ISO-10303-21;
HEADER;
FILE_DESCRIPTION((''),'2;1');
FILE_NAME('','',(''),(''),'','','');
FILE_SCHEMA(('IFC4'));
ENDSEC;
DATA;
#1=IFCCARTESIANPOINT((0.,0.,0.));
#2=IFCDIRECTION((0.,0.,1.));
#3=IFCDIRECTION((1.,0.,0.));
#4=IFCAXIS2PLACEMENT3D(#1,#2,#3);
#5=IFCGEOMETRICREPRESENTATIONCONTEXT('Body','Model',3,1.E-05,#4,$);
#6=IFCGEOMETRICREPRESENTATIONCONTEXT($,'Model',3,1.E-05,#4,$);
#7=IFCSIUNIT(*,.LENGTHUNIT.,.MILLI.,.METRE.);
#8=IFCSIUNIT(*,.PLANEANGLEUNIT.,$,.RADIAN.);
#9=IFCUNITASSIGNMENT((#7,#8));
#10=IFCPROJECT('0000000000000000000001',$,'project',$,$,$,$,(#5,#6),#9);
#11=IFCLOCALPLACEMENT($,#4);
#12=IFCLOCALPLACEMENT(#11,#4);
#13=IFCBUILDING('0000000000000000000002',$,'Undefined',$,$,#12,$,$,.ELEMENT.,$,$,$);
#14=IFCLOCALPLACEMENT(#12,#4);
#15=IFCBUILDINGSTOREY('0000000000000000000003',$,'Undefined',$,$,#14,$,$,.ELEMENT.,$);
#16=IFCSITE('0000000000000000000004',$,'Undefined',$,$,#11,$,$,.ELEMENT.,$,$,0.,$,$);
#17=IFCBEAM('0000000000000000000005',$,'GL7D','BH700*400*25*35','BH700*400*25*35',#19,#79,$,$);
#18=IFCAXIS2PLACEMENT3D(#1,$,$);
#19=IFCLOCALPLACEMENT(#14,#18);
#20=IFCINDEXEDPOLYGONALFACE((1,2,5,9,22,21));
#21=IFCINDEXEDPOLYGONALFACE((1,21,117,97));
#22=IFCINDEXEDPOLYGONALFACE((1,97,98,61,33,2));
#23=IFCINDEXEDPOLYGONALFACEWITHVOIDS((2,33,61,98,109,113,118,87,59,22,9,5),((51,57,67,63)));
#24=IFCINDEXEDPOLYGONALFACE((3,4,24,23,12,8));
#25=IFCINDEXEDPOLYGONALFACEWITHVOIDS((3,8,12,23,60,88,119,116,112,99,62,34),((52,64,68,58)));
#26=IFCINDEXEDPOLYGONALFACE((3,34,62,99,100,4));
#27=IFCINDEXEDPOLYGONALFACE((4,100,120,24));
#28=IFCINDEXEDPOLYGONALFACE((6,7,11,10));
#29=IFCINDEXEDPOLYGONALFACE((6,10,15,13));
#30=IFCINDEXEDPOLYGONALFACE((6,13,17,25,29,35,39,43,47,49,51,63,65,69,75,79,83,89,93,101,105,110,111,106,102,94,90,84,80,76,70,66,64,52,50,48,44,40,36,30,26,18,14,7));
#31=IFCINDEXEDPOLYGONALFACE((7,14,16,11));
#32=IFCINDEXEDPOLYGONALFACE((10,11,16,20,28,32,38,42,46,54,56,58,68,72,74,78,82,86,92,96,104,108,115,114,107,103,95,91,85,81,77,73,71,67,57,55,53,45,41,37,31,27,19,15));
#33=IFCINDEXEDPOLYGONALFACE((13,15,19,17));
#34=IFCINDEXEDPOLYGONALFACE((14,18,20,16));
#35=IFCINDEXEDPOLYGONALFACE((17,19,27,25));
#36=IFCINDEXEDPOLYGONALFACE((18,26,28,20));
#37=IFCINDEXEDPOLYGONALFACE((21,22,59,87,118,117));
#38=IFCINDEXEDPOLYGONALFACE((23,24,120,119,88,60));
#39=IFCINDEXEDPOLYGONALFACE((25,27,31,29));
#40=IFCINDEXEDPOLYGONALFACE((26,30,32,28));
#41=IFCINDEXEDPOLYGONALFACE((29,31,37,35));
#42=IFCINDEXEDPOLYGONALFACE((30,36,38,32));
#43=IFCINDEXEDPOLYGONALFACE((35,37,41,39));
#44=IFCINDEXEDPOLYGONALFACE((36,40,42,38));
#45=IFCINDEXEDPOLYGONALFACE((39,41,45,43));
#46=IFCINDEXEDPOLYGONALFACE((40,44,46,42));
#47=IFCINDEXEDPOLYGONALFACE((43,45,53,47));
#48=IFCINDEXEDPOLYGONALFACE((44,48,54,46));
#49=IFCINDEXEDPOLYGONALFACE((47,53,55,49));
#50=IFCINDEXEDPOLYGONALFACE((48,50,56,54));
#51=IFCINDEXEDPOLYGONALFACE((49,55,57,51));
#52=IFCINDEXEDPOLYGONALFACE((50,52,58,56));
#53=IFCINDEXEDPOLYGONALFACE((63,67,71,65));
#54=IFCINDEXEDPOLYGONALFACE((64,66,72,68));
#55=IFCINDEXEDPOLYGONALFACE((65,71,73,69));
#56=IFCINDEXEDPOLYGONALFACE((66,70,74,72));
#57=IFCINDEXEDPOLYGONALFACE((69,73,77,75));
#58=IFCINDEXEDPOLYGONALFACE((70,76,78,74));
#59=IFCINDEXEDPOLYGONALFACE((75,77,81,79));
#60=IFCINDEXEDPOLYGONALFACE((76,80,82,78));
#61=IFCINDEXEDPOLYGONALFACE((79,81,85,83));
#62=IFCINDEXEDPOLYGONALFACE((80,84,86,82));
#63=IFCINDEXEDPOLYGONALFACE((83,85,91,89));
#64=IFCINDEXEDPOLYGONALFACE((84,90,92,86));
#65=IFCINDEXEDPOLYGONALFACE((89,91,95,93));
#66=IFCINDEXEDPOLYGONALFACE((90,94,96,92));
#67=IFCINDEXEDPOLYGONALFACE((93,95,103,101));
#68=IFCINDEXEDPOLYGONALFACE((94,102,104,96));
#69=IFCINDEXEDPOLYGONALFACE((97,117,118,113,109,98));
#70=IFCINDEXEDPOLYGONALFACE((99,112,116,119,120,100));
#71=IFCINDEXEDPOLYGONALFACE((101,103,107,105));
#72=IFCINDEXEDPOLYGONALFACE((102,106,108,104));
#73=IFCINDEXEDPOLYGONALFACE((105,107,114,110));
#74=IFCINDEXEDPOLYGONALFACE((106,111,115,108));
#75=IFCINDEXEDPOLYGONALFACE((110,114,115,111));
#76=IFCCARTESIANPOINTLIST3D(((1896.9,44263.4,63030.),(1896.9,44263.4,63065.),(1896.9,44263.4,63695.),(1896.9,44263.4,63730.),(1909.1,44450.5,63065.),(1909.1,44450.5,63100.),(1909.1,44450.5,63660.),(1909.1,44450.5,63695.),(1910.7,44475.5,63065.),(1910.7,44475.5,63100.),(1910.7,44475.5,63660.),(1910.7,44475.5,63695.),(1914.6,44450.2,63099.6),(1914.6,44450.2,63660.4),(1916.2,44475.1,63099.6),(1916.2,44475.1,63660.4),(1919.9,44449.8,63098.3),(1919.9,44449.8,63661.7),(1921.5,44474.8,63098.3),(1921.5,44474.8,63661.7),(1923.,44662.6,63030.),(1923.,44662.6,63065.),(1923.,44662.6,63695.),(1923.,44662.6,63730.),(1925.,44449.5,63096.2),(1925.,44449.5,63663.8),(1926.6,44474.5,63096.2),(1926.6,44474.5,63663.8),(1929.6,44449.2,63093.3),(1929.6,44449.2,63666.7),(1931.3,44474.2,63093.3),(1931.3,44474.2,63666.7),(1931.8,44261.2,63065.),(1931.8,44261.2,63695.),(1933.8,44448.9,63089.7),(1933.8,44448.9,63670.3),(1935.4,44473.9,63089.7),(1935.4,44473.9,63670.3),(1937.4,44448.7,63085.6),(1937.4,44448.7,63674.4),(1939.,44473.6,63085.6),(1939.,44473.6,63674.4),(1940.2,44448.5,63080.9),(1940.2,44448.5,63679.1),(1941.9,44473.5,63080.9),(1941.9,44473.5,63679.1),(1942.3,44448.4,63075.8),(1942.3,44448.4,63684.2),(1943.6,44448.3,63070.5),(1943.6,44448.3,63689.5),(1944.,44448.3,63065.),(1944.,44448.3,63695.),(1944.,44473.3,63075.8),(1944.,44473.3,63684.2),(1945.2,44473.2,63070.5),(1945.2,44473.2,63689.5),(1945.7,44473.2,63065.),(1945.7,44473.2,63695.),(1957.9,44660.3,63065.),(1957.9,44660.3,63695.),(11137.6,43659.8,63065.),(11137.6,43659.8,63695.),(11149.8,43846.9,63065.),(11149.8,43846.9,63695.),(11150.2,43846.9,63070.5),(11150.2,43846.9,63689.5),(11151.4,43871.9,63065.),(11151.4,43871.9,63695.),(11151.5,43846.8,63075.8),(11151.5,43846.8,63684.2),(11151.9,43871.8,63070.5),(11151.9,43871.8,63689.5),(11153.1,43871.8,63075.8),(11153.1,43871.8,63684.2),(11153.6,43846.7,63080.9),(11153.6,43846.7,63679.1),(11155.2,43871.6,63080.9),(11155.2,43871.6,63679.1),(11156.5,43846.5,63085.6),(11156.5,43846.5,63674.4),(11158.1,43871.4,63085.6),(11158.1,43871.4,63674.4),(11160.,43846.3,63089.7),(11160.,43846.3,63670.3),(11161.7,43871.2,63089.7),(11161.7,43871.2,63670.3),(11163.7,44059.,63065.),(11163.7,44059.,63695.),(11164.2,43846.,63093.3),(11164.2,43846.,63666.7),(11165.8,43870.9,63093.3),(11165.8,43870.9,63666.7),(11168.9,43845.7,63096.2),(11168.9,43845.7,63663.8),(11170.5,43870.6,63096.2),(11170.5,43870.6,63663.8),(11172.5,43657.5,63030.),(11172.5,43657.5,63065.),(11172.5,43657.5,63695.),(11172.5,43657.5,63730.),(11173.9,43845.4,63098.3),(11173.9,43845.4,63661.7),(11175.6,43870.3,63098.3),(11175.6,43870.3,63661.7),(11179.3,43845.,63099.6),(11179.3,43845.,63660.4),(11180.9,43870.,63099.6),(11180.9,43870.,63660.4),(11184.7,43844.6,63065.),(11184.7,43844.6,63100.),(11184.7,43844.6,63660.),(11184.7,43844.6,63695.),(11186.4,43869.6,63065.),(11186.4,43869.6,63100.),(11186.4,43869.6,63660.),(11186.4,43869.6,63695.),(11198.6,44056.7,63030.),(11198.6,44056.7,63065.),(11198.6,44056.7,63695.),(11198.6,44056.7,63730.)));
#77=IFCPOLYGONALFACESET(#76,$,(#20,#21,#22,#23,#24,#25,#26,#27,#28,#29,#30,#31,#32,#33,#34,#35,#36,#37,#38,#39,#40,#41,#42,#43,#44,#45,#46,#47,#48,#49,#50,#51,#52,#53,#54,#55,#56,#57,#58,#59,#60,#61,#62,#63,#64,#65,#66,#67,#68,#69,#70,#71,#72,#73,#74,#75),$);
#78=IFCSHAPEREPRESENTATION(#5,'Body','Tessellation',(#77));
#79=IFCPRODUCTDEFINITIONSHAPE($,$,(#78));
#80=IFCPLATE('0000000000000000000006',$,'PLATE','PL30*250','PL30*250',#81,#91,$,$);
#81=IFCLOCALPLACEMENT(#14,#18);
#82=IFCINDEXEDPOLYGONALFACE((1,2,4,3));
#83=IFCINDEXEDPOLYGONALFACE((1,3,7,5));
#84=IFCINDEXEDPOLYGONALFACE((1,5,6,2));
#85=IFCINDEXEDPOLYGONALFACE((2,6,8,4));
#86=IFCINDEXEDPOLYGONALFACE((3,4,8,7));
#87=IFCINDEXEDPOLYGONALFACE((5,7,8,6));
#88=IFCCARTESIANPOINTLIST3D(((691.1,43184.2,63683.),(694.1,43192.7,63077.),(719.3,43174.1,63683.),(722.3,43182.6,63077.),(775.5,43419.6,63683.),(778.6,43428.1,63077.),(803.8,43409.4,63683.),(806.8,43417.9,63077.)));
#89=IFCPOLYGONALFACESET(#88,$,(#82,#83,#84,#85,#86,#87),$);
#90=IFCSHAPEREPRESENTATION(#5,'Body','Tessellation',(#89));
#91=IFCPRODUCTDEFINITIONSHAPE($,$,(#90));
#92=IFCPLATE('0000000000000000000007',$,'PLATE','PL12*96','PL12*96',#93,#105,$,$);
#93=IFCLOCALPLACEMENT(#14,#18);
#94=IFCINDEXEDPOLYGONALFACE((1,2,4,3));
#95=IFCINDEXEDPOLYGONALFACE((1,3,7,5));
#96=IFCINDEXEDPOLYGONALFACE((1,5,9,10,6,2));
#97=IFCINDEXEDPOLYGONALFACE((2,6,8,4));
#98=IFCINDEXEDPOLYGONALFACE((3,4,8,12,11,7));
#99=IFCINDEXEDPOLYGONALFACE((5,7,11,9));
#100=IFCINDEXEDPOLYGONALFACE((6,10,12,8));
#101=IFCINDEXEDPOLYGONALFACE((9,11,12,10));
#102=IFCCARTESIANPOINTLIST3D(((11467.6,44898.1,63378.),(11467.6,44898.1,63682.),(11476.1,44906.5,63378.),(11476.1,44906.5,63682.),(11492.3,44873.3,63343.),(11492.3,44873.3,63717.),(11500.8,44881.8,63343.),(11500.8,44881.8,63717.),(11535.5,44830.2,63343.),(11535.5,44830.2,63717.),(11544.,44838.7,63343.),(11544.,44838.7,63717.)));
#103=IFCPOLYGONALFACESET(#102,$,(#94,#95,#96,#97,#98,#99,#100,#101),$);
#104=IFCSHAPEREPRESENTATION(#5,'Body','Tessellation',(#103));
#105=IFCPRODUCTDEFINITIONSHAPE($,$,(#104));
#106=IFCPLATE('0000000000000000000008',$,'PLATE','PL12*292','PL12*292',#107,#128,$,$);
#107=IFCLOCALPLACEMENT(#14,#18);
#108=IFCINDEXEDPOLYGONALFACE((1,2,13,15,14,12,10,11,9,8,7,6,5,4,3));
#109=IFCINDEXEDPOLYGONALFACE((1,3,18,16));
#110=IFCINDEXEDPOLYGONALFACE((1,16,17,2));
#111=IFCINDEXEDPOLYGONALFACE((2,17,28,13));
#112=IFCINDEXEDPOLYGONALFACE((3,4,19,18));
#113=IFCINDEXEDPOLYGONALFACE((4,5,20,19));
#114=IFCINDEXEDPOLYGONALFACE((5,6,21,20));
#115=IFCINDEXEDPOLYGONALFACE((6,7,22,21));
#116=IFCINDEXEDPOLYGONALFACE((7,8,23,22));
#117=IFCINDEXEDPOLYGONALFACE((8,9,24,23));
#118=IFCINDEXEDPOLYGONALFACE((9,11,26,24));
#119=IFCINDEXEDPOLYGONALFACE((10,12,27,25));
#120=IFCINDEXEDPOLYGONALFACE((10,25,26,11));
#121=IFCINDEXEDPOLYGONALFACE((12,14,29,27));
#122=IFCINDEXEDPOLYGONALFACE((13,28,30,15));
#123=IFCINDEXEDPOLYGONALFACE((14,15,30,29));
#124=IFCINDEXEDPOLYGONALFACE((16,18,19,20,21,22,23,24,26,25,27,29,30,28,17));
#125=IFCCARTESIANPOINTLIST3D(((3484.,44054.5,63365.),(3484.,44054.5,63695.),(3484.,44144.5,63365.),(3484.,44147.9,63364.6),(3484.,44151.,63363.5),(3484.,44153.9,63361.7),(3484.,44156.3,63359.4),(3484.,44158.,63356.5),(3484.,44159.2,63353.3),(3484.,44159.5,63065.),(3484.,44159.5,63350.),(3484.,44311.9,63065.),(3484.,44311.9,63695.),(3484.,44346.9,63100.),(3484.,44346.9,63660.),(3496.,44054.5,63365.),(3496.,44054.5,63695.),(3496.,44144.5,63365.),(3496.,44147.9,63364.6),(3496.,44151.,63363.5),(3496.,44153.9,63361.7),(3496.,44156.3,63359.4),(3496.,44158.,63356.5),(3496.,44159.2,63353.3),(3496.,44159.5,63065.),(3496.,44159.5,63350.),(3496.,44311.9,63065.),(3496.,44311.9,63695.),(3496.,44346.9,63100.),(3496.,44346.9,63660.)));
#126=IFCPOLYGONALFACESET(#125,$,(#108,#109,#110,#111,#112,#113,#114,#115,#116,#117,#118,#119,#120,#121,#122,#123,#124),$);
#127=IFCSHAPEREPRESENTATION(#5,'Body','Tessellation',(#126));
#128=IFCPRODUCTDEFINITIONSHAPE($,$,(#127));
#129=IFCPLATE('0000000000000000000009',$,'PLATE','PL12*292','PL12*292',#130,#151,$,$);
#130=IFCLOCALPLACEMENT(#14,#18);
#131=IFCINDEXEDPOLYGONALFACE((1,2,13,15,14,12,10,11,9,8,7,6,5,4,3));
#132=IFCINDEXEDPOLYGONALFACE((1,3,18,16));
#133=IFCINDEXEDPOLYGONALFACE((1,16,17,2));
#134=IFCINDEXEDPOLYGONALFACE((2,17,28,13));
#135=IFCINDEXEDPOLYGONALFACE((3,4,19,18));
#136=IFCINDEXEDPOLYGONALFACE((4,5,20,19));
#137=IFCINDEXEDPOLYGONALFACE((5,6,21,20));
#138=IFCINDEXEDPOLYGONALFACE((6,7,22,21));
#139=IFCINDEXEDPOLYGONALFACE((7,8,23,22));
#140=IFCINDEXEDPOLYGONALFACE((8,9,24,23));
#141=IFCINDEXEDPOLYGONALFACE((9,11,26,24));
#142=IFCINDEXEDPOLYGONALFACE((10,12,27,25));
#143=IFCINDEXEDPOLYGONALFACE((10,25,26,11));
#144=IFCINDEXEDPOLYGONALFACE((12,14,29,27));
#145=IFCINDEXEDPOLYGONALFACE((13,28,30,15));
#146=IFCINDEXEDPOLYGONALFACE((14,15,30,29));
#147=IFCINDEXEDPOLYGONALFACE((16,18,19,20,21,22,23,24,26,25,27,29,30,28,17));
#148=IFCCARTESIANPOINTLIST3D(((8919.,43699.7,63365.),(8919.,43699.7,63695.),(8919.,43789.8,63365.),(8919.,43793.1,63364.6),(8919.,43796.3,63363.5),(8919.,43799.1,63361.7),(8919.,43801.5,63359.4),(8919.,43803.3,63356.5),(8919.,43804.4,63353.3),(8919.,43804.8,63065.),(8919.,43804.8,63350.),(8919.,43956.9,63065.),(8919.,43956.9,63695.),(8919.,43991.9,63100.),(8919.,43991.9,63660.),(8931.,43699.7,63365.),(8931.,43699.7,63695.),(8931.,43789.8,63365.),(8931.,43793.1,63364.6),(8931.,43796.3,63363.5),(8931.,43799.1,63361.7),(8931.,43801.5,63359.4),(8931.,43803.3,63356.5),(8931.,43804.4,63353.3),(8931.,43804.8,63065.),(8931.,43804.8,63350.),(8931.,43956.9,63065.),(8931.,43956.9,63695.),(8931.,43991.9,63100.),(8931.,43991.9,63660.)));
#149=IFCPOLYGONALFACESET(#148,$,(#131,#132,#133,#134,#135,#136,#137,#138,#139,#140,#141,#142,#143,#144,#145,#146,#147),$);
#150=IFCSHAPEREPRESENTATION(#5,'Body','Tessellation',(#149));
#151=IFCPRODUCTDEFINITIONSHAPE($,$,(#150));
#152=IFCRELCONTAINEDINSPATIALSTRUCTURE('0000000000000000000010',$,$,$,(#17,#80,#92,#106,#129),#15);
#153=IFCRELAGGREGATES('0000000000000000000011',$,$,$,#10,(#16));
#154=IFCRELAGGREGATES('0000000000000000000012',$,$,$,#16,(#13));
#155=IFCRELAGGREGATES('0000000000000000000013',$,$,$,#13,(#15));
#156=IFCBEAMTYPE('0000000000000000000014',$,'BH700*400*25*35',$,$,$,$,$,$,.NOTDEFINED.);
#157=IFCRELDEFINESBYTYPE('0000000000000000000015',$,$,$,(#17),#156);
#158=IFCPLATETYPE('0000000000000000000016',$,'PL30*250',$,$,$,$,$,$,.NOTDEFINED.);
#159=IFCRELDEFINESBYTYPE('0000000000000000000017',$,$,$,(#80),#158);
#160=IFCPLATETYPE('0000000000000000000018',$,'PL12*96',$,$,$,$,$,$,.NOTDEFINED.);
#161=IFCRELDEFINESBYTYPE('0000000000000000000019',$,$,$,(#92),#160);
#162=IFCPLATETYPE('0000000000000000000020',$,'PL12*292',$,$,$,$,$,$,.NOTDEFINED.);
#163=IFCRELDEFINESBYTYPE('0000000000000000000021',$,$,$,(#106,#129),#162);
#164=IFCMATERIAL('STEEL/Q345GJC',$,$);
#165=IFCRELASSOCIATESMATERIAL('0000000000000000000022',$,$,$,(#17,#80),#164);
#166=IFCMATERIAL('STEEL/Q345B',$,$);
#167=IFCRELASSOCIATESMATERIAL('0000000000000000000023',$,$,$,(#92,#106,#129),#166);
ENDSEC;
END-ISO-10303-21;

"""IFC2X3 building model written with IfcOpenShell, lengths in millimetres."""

from ifc_helpers import new_model, si_unit, frame, origin_with_axes, origin_2d_with_axis, place, context, project, spatial, polyline, i_section, outline, extrude, material, type_object, element, save


model = new_model("IFC2X3")

# Units and contexts
model_context_1 = context("Model", 3, precision=1e-05, world=origin_with_axes(), identifier="Body")
model_context_2 = context("Model", 3, precision=1e-05, world=origin_with_axes())
ifc_project = project(units=[si_unit("LENGTHUNIT", "METRE", prefix="MILLI"), si_unit("PLANEANGLEUNIT", "RADIAN")], contexts=[model_context_1, model_context_2])

# Site, building, storey
site_placement = place(None, origin_with_axes())
site = spatial("IfcSite", under=ifc_project, at=site_placement, Name="Undefined", CompositionType="ELEMENT", RefElevation=0.0)
building_placement = place(site_placement, origin_with_axes())
building = spatial("IfcBuilding", under=site, at=building_placement, Name="Undefined", CompositionType="ELEMENT")
storey_placement = place(building_placement, origin_with_axes())
storey = spatial("IfcBuildingStorey", under=building, at=storey_placement, Name="Undefined", CompositionType="ELEMENT")

# Shared definitions
ifc_material_1 = material(Name="STEEL/Q345B")
ifc_material_2 = material(Name="STEEL/Q345GJC")

# Beam, openings
beam_type_1 = type_object("IfcBeamType", Name="BH700*400*25*35", PredefinedType="NOTDEFINED")
beam_1_placement = place(storey_placement, frame((992.3, 44523.0, 63380.0), z_axis=(0.0, 0.0, 1.0), x_axis=(0.997873, -0.065183, 0.0)))
beam_1 = element("IfcBeam", 1, at=beam_1_placement, inside=storey, type_object=beam_type_1, material=ifc_material_2, Name="GL7D", Description="BH700*400*25*35", ObjectType="BH700*400*25*35", context=model_context_1, shape_type="SweptSolid", body=[
    extrude(i_section(OverallWidth=400.0, OverallDepth=700.0, WebThickness=25.0, FlangeThickness=35.0, at=origin_2d_with_axis()), frame((10215.0, 0.0, 0.0), z_axis=(-1.0, 0.0, 0.0), x_axis=(0.0, -1.0, 0.0)), (0.0, 0.0, 1.0), 9295.4),
])
opening_1_placement = place(storey_placement, frame((992.3, 44523.0, 63380.0), z_axis=(0.0, 0.0, 1.0), x_axis=(0.997873, -0.065183, 0.0)))
element("IfcOpeningElement", 2, at=opening_1_placement, cuts=beam_1, ObjectType="Recess", context=model_context_1, shape_type="SweptSolid", body=[
    extrude(outline(polyline([(0.0, 0.0), (37.0, 0.0), (37.0, 35.0), (35.0, 35.0), (29.5, 34.6), (24.2, 33.3), (19.1, 31.2), (14.4, 28.3), (10.3, 24.7), (6.7, 20.6), (3.8, 15.9), (1.7, 10.8), (0.4, 5.5), (0.0, 0.0), (0.0, 0.0)])), frame((10180.0, -200.0, 315.0), z_axis=(0.0, 1.0, 0.0), x_axis=(1.0, 0.0, 0.0)), (0.0, 0.0, 1.0), 400.0),
])
opening_2_placement = place(storey_placement, frame((992.3, 44523.0, 63380.0), z_axis=(0.0, 0.0, 1.0), x_axis=(0.997873, -0.065183, 0.0)))
element("IfcOpeningElement", 3, at=opening_2_placement, cuts=beam_1, ObjectType="Recess", context=model_context_1, shape_type="SweptSolid", body=[
    extrude(outline(polyline([(0.0, 0.0), (37.0, 0.0), (36.6, 5.5), (35.3, 10.8), (33.2, 15.9), (30.3, 20.6), (26.7, 24.7), (22.6, 28.3), (17.9, 31.2), (12.8, 33.3), (7.5, 34.6), (2.0, 35.0), (0.0, 35.0), (0.0, 0.0)])), frame((10217.0, -200.0, -315.0), z_axis=(0.0, 1.0, 0.0), x_axis=(-1.0, 0.0, 0.0)), (0.0, 0.0, 1.0), 400.0),
])
opening_3_placement = place(storey_placement, frame((992.3, 44523.0, 63380.0), z_axis=(0.0, 0.0, 1.0), x_axis=(0.997873, -0.065183, 0.0)))
element("IfcOpeningElement", 4, at=opening_3_placement, cuts=beam_1, ObjectType="Recess", context=model_context_1, shape_type="SweptSolid", body=[
    extrude(outline(polyline([(0.0, 0.0), (37.0, 0.0), (37.0, 35.0), (35.0, 35.0), (29.5, 34.6), (24.2, 33.3), (19.1, 31.2), (14.4, 28.3), (10.3, 24.7), (6.7, 20.6), (3.8, 15.9), (1.7, 10.8), (0.4, 5.5), (0.0, 0.0), (0.0, 0.0)])), frame((954.6, 200.0, 315.0), z_axis=(0.0, -1.0, 0.0), x_axis=(-1.0, 0.0, 0.0)), (0.0, 0.0, 1.0), 400.0),
])
opening_4_placement = place(storey_placement, frame((992.3, 44523.0, 63380.0), z_axis=(0.0, 0.0, 1.0), x_axis=(0.997873, -0.065183, 0.0)))
element("IfcOpeningElement", 5, at=opening_4_placement, cuts=beam_1, ObjectType="Recess", context=model_context_1, shape_type="SweptSolid", body=[
    extrude(outline(polyline([(0.0, 0.0), (37.0, 0.0), (36.6, 5.5), (35.3, 10.8), (33.2, 15.9), (30.3, 20.6), (26.7, 24.7), (22.6, 28.3), (17.9, 31.2), (12.8, 33.3), (7.5, 34.6), (2.0, 35.0), (0.0, 35.0), (0.0, 0.0)])), frame((917.6, 200.0, -315.0), z_axis=(0.0, -1.0, 0.0), x_axis=(1.0, 0.0, 0.0)), (0.0, 0.0, 1.0), 400.0),
])
opening_5_placement = place(storey_placement, frame((992.3, 44523.0, 63380.0), z_axis=(0.0, 0.0, 1.0), x_axis=(0.997873, -0.065183, 0.0)))
element("IfcOpeningElement", 6, at=opening_5_placement, cuts=beam_1, ObjectType="Recess", context=model_context_1, shape_type="SweptSolid", body=[
    extrude(outline(polyline([(0.0, 0.0), (37.0, 0.0), (37.0, 35.0), (35.0, 35.0), (29.5, 34.6), (24.2, 33.3), (19.1, 31.2), (14.4, 28.3), (10.3, 24.7), (6.7, 20.6), (3.8, 15.9), (1.7, 10.8), (0.4, 5.5), (0.0, 0.0), (0.0, 0.0)])), frame((10437.3, 10608.1, 315.0), z_axis=(-0.991502, -0.130088, 0.0), x_axis=(-0.130088, 0.991502, 0.0)), (0.0, 0.0, 1.0), 400.0),
])
opening_6_placement = place(storey_placement, frame((992.3, 44523.0, 63380.0), z_axis=(0.0, 0.0, 1.0), x_axis=(0.997873, -0.065183, 0.0)))
element("IfcOpeningElement", 7, at=opening_6_placement, cuts=beam_1, ObjectType="Recess", context=model_context_1, shape_type="SweptSolid", body=[
    extrude(outline(polyline([(0.0, 0.0), (37.0, 0.0), (36.6, 5.5), (35.3, 10.8), (33.2, 15.9), (30.3, 20.6), (26.7, 24.7), (22.6, 28.3), (17.9, 31.2), (12.8, 33.3), (7.5, 34.6), (2.0, 35.0), (0.0, 35.0), (0.0, 0.0)])), frame((10432.5, 10644.8, -315.0), z_axis=(-0.991502, -0.130088, 0.0), x_axis=(0.130088, -0.991502, 0.0)), (0.0, 0.0, 1.0), 400.0),
])

# Plates
plate_type_1 = type_object("IfcPlateType", Name="PL30*250", PredefinedType="NOTDEFINED")
plate_1_placement = place(storey_placement, frame((705.2, 43179.2, 63683.0), z_axis=(-0.941212, 0.337816, 0.0), x_axis=(0.337816, 0.941212, 0.0)))
element("IfcPlate", 8, at=plate_1_placement, inside=storey, type_object=plate_type_1, material=ifc_material_2, Name="PLATE", Description="PL30*250", ObjectType="PL30*250", context=model_context_1, shape_type="SweptSolid", body=[
    extrude(outline(polyline([(0.0, 0.0), (250.0, 0.0), (259.0, 606.0), (9.0, 606.0), (0.0, 0.0)])), frame((0.0, 0.0, -15.0), z_axis=(0.0, 0.0, 1.0), x_axis=(1.0, 0.0, 0.0)), (0.0, 0.0, 1.0), 30.0),
])
plate_type_2 = type_object("IfcPlateType", Name="PL12*96", PredefinedType="NOTDEFINED")
plate_2_placement = place(storey_placement, frame((11471.8, 44902.3, 63343.0), z_axis=(-0.707107, -0.707107, 0.0), x_axis=(0.707107, -0.707107, 0.0)))
element("IfcPlate", 9, at=plate_2_placement, inside=storey, type_object=plate_type_2, material=ifc_material_1, Name="PLATE", Description="PL12*96", ObjectType="PL12*96", context=model_context_1, shape_type="SweptSolid", body=[
    extrude(outline(polyline([(0.0, 35.0), (35.0, 0.0), (96.0, 0.0), (96.0, 374.0), (35.0, 374.0), (0.0, 339.0), (0.0, 35.0)])), frame((0.0, 0.0, -6.0), z_axis=(0.0, 0.0, 1.0), x_axis=(1.0, 0.0, 0.0)), (0.0, 0.0, 1.0), 12.0),
])
plate_type_3 = type_object("IfcPlateType", Name="PL12*292", PredefinedType="NOTDEFINED")
plate_3_placement = place(storey_placement, frame((3490.0, 44054.5, 63695.0), z_axis=(-1.0, 0.0, 0.0), x_axis=(0.0, 1.0, 0.0)))
element("IfcPlate", 10, at=plate_3_placement, inside=storey, type_object=plate_type_3, material=ifc_material_1, Name="PLATE", Description="PL12*292", ObjectType="PL12*292", context=model_context_1, shape_type="SweptSolid", body=[
    extrude(outline(polyline([(0.0, 0.0), (257.4, 0.0), (292.4, 35.0), (292.4, 595.0), (257.4, 630.0), (105.1, 630.0), (105.1, 345.0), (104.7, 341.7), (103.6, 338.5), (101.8, 335.6), (99.4, 333.3), (96.6, 331.5), (93.4, 330.4), (90.1, 330.0), (0.0, 330.0), (0.0, 0.0)])), frame((0.0, 0.0, -6.0), z_axis=(0.0, 0.0, 1.0), x_axis=(1.0, 0.0, 0.0)), (0.0, 0.0, 1.0), 12.0),
])
for number, where, z_axis, x_axis, name in (
    (11, (8925.0, 43699.7, 63695.0), (-1.0, 0.0, 0.0), (0.0, 1.0, 0.0), "PLATE"),
):
    element("IfcPlate", number, at=place(storey_placement, frame(where, z_axis=z_axis, x_axis=x_axis)), inside=storey, type_object=plate_type_3, material=ifc_material_1, Name=name, Description="PL12*292", ObjectType="PL12*292", context=model_context_1, shape_type="SweptSolid", body=[
        extrude(outline(polyline([(0.0, 0.0), (257.2, 0.0), (292.2, 35.0), (292.2, 595.0), (257.2, 630.0), (105.1, 630.0), (105.1, 345.0), (104.7, 341.7), (103.6, 338.5), (101.8, 335.6), (99.4, 333.3), (96.6, 331.5), (93.4, 330.4), (90.1, 330.0), (0.0, 330.0), (0.0, 0.0)])), frame((0.0, 0.0, -6.0), z_axis=(0.0, 0.0, 1.0), x_axis=(1.0, 0.0, 0.0)), (0.0, 0.0, 1.0), 12.0),
    ])

save(model, "model.ifc")
